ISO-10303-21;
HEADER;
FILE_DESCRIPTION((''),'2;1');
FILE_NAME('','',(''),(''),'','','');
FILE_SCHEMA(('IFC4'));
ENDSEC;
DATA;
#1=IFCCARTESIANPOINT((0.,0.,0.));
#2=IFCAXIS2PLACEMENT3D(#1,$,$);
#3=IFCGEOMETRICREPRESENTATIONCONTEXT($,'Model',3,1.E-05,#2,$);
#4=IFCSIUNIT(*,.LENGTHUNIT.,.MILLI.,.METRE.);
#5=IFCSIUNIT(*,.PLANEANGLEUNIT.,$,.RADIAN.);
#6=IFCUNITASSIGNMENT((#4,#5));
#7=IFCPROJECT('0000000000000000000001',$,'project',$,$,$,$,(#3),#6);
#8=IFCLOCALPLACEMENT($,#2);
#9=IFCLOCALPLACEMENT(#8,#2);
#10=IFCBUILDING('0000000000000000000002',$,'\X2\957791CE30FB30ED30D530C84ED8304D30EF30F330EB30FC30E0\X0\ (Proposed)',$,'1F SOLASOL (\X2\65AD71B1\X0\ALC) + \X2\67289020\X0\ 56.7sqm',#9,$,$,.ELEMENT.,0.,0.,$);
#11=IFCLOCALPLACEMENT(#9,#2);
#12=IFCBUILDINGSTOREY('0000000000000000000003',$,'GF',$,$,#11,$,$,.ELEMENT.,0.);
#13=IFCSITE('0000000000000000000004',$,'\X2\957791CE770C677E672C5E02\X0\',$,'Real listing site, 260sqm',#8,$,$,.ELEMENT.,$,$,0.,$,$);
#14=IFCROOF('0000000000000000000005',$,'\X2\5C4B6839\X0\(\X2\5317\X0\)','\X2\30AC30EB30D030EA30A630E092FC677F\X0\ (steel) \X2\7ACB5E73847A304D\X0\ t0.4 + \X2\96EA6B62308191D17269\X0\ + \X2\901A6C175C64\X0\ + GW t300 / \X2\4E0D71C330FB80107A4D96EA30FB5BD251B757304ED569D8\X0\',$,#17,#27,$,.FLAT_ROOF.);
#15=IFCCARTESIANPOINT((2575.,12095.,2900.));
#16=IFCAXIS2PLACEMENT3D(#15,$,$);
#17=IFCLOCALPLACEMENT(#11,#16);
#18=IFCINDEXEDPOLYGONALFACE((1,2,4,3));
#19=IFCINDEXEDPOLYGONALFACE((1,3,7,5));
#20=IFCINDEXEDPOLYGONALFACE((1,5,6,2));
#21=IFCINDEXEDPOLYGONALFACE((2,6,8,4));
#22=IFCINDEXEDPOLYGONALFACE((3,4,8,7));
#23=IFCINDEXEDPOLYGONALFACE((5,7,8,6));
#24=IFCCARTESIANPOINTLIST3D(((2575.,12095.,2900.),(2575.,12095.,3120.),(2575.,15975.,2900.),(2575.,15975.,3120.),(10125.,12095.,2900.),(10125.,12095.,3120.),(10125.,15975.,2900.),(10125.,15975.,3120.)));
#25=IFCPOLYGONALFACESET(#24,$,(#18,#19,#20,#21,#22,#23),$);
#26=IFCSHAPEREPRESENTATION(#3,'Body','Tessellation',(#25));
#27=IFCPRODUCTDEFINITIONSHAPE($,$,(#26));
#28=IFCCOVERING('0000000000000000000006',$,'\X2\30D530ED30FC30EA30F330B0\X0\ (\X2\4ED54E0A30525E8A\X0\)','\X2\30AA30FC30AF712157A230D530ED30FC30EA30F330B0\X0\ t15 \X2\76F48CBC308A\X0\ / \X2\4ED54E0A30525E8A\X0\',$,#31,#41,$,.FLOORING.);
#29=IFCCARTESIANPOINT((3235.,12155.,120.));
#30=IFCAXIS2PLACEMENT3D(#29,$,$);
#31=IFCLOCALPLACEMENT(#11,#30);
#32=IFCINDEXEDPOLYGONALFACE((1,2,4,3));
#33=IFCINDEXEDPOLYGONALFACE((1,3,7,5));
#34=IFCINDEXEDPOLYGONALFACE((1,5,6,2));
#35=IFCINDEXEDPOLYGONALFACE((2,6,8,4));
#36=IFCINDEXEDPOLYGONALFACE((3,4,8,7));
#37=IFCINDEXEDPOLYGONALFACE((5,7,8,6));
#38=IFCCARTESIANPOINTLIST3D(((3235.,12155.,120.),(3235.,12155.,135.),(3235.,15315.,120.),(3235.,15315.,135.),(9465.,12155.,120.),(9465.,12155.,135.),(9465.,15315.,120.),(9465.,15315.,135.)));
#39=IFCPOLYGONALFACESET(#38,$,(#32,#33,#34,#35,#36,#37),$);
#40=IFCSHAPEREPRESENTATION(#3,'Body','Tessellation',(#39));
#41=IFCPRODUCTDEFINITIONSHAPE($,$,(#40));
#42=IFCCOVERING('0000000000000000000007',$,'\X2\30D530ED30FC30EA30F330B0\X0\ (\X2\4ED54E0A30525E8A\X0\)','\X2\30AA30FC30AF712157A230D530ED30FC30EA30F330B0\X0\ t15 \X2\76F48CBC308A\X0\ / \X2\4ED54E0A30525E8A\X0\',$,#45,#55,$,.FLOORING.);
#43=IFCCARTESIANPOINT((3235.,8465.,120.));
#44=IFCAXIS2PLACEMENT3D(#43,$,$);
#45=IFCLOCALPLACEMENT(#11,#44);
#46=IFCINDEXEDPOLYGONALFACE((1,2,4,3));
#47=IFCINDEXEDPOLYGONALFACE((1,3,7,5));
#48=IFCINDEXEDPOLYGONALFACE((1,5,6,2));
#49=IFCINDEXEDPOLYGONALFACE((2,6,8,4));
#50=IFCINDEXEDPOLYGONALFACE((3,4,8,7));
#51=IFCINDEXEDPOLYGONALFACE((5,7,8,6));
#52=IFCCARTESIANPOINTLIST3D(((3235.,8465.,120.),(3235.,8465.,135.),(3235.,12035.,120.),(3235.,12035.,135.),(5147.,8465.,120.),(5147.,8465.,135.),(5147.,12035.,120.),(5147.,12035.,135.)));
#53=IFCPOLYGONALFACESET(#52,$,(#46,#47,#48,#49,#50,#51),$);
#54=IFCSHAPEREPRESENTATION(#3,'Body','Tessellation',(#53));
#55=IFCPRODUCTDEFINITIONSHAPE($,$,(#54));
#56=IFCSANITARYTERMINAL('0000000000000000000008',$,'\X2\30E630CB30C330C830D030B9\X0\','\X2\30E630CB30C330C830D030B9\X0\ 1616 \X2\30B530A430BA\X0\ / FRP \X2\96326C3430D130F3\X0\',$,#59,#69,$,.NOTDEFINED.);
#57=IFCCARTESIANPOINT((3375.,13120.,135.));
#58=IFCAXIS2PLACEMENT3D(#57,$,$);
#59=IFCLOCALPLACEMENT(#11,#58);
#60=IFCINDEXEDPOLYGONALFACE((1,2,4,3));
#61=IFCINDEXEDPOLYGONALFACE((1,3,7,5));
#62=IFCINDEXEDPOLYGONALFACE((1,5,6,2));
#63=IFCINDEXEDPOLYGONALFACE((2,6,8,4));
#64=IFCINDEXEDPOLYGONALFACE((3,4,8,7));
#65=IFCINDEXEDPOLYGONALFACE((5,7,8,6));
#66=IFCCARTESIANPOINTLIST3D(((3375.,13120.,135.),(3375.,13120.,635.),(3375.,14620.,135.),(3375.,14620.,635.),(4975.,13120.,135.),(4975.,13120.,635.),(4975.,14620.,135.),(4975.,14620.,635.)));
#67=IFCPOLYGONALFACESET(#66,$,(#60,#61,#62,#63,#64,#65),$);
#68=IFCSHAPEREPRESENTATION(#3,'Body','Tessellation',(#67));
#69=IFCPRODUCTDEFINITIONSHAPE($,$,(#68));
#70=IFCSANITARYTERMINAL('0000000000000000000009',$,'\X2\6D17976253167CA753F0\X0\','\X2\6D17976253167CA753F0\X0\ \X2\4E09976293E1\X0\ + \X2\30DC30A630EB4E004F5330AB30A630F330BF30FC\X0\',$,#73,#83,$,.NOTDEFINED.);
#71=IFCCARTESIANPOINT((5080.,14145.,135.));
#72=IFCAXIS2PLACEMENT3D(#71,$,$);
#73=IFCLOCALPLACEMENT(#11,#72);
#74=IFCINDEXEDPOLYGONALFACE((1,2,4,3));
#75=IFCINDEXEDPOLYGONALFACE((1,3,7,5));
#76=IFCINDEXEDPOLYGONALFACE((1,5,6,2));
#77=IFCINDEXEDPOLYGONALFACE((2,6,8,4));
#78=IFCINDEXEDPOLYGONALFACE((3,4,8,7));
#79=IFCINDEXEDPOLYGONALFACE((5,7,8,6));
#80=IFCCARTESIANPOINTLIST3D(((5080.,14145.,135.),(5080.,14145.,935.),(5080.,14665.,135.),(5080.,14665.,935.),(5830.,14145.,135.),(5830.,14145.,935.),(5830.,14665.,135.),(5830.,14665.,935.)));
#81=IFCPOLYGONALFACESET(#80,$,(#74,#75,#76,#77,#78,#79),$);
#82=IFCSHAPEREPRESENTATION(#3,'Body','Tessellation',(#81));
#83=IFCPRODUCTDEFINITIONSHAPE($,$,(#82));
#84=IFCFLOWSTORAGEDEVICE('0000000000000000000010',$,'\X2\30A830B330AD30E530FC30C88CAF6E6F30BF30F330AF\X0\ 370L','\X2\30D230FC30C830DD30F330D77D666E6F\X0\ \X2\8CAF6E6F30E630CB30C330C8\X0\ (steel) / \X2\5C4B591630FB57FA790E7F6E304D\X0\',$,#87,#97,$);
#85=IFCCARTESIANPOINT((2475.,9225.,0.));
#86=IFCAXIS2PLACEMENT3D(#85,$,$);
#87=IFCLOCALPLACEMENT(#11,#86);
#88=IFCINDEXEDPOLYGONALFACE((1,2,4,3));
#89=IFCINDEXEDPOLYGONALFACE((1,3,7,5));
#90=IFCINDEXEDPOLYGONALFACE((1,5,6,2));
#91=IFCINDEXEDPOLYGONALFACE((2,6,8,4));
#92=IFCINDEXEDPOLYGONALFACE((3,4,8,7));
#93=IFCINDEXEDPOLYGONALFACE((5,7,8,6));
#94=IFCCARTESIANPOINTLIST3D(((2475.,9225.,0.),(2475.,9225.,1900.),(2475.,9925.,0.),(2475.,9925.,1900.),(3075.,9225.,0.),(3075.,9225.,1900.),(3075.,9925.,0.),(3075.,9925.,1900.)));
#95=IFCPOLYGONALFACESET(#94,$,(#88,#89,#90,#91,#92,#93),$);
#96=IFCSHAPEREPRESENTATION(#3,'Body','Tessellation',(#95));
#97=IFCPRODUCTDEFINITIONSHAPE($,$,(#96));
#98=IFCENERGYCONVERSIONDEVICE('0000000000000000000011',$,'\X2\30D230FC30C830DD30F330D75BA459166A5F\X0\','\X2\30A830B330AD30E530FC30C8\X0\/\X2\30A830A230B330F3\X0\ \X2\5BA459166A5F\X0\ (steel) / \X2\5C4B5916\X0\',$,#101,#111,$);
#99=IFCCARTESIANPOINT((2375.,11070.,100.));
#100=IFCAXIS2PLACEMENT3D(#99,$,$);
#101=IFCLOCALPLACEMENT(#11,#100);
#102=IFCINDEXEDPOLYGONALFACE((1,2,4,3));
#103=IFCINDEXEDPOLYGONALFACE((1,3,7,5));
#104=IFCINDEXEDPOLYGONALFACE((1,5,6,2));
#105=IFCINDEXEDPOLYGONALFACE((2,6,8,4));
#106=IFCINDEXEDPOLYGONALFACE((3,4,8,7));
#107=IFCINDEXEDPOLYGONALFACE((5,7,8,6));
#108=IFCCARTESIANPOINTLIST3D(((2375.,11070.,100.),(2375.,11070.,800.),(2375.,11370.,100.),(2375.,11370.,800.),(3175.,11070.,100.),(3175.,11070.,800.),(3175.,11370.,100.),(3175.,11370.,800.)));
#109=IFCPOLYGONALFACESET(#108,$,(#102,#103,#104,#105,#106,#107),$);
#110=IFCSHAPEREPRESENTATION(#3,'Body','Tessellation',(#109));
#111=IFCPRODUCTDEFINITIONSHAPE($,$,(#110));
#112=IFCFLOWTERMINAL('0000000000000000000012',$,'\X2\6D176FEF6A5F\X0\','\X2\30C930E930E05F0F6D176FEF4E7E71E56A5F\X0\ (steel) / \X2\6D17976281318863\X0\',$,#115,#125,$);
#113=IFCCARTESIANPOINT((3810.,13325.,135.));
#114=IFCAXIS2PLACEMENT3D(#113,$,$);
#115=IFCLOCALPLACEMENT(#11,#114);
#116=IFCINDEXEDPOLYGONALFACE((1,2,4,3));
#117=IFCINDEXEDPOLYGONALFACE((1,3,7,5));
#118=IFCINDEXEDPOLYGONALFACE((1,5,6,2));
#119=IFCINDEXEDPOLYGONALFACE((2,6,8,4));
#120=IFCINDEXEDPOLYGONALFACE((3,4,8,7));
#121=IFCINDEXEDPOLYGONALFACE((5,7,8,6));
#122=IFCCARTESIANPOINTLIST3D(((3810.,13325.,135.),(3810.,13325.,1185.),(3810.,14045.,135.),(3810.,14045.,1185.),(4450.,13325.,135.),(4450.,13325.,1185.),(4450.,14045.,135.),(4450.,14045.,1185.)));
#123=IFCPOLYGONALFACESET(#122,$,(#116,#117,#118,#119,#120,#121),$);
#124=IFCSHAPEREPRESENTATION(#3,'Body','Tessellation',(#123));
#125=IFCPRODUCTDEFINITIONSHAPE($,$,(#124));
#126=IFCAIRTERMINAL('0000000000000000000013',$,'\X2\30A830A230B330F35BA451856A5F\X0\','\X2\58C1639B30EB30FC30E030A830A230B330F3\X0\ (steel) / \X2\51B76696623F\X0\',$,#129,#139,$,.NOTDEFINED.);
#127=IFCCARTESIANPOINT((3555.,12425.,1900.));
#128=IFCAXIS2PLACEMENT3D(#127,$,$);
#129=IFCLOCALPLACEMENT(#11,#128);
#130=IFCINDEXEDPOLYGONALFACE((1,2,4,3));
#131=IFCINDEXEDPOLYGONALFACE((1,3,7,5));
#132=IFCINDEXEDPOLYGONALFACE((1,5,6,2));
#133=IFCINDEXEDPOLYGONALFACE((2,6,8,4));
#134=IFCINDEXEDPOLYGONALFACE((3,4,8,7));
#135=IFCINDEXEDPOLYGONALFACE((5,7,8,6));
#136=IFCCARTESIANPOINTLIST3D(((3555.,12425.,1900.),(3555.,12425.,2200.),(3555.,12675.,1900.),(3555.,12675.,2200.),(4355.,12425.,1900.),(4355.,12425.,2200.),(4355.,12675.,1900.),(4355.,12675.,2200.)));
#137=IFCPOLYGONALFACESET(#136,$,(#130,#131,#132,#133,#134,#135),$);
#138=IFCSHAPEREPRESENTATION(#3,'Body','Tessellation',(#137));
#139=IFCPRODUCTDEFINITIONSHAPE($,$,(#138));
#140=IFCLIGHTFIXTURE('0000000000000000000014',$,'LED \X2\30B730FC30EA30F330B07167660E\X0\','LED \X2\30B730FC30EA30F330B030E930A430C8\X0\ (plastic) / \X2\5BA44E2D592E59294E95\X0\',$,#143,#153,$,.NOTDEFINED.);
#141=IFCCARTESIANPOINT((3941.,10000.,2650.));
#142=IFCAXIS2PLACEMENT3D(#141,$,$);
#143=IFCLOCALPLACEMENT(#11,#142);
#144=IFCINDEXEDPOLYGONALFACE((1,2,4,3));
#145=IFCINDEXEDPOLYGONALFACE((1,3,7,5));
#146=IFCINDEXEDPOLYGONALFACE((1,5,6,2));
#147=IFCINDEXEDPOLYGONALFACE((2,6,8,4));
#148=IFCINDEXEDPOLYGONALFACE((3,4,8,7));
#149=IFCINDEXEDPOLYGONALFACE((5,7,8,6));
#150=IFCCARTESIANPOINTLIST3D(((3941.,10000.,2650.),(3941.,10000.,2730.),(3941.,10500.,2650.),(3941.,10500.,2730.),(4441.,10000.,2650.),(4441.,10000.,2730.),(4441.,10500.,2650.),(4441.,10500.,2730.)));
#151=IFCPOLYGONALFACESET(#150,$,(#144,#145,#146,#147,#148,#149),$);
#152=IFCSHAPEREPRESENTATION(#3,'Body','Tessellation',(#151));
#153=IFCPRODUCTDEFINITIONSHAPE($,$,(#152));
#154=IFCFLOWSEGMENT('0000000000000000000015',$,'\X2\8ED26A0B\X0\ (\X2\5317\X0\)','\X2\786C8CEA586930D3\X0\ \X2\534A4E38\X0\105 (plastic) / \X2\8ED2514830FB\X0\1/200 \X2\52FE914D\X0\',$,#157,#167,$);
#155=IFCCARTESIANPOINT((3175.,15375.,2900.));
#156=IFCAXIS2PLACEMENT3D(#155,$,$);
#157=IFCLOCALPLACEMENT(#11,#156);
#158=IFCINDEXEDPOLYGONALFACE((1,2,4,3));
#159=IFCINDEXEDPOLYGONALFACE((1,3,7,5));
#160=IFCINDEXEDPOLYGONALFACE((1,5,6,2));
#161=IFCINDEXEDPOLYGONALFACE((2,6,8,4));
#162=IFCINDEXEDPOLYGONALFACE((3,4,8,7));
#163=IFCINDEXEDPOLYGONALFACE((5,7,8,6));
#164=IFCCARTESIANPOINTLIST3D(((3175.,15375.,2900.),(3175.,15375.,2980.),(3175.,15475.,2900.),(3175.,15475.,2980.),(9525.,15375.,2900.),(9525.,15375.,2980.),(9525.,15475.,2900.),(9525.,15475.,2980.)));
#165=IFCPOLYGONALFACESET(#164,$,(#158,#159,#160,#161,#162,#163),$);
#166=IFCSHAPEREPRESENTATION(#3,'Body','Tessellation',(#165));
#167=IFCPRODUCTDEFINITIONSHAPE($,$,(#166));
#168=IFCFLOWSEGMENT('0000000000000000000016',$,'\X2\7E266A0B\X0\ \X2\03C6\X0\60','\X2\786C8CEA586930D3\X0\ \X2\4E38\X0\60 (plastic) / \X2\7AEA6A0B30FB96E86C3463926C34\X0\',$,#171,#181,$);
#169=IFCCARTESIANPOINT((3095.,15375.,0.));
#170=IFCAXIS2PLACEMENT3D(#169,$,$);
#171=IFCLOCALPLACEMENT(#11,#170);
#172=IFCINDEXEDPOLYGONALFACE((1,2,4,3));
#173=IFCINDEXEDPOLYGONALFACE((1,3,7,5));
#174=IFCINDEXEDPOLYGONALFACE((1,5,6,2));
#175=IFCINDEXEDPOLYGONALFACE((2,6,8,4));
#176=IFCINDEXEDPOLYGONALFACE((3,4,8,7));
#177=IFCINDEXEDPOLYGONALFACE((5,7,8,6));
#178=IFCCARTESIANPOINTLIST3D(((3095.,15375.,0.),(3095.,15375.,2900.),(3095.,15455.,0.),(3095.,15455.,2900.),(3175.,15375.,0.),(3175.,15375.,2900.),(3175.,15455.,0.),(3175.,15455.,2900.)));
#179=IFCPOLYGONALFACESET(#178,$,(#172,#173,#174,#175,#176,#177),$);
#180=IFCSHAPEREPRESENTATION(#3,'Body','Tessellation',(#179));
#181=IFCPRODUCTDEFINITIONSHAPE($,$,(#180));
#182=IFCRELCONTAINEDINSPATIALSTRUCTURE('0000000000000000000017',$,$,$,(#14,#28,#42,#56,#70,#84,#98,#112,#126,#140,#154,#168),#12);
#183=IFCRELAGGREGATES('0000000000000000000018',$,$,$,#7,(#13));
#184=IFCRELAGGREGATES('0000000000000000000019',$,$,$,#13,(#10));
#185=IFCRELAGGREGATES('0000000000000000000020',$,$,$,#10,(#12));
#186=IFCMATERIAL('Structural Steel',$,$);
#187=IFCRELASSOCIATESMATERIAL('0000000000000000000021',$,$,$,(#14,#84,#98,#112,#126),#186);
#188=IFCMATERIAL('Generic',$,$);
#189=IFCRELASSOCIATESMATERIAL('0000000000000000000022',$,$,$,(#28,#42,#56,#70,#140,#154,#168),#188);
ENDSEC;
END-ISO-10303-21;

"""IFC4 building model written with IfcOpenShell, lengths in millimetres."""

from ifc_helpers import new_model, si_unit, frame, frame_2d, origin, place, context, project, spatial, rectangle, extrude, material, element, save


model = new_model("IFC4")

# Units and contexts
model_context = context("Model", 3, precision=1e-05, world=origin())
ifc_project = project(units=[si_unit("LENGTHUNIT", "METRE", prefix="MILLI"), si_unit("PLANEANGLEUNIT", "RADIAN")], contexts=[model_context])

# Site, building, storey
site_placement = place(None, origin())
site = spatial("IfcSite", under=ifc_project, at=site_placement, Name="長野県松本市", ObjectType="Real listing site, 260sqm", CompositionType="ELEMENT", RefElevation=0.0)
building_placement = place(site_placement, origin())
building = spatial("IfcBuilding", under=site, at=building_placement, Name="長野・ロフト付きワンルーム (Proposed)", ObjectType="1F SOLASOL (断熱ALC) + 木造 56.7sqm", CompositionType="ELEMENT", ElevationOfRefHeight=0.0, ElevationOfTerrain=0.0)
storey_placement = place(building_placement, origin())
storey = spatial("IfcBuildingStorey", under=building, at=storey_placement, Name="GF", CompositionType="ELEMENT", Elevation=0.0)

# Roof
ifc_material_1 = material(Name="Structural Steel")
roof_placement = place(storey_placement, frame((2575.0, 12095.0, 2900.0)))
element("IfcRoof", 1, at=roof_placement, inside=storey, material=ifc_material_1, Name="屋根(北)", Description="ガルバリウム鋼板 (steel) 立平葺き t0.4 + 雪止め金物 + 通気層 + GW t300 / 不燃・耐積雪・寒冷地仕様", PredefinedType="FLAT_ROOF", context=model_context, shape_type="SweptSolid", body=[
    extrude(rectangle(XDim=7550.0, YDim=3880.0, at=frame_2d((3775.0, 1940.0))), frame((2575.0, 12095.0, 2900.0)), (0.0, 0.0, 1.0), 220.0),
])

# Coverings
ifc_material_2 = material(Name="Generic")
covering_1_placement = place(storey_placement, frame((3235.0, 12155.0, 120.0)))
element("IfcCovering", 2, at=covering_1_placement, inside=storey, material=ifc_material_2, Name="フローリング (仕上げ床)", Description="オーク無垢フローリング t15 直貼り / 仕上げ床", PredefinedType="FLOORING", context=model_context, shape_type="SweptSolid", body=[
    extrude(rectangle(XDim=6230.0, YDim=3160.0, at=frame_2d((3115.0, 1580.0))), frame((3235.0, 12155.0, 120.0)), (0.0, 0.0, 1.0), 15.0),
])
covering_2_placement = place(storey_placement, frame((3235.0, 8465.0, 120.0)))
element("IfcCovering", 3, at=covering_2_placement, inside=storey, material=ifc_material_2, Name="フローリング (仕上げ床)", Description="オーク無垢フローリング t15 直貼り / 仕上げ床", PredefinedType="FLOORING", context=model_context, shape_type="SweptSolid", body=[
    extrude(rectangle(XDim=1912.0, YDim=3570.0, at=frame_2d((956.0, 1785.0))), frame((3235.0, 8465.0, 120.0)), (0.0, 0.0, 1.0), 15.0),
])

# Sanitary terminals
sanitary_terminal_1_placement = place(storey_placement, frame((3375.0, 13120.0, 135.0)))
element("IfcSanitaryTerminal", 4, at=sanitary_terminal_1_placement, inside=storey, material=ifc_material_2, Name="ユニットバス", Description="ユニットバス 1616 サイズ / FRP 防水パン", PredefinedType="NOTDEFINED", context=model_context, shape_type="SweptSolid", body=[
    extrude(rectangle(XDim=1600.0, YDim=1500.0, at=frame_2d((800.0, 750.0))), frame((3375.0, 13120.0, 135.0)), (0.0, 0.0, 1.0), 500.0),
])
sanitary_terminal_2_placement = place(storey_placement, frame((5080.0, 14145.0, 135.0)))
element("IfcSanitaryTerminal", 5, at=sanitary_terminal_2_placement, inside=storey, material=ifc_material_2, Name="洗面化粧台", Description="洗面化粧台 三面鏡 + ボウル一体カウンター", PredefinedType="NOTDEFINED", context=model_context, shape_type="SweptSolid", body=[
    extrude(rectangle(XDim=750.0, YDim=520.0, at=frame_2d((375.0, 260.0))), frame((5080.0, 14145.0, 135.0)), (0.0, 0.0, 1.0), 800.0),
])

# Flow storage device
flow_storage_device_placement = place(storey_placement, frame((2475.0, 9225.0, 0.0)))
element("IfcFlowStorageDevice", 6, at=flow_storage_device_placement, inside=storey, material=ifc_material_1, Name="エコキュート貯湯タンク 370L", Description="ヒートポンプ給湯 貯湯ユニット (steel) / 屋外・基礎置き", context=model_context, shape_type="SweptSolid", body=[
    extrude(rectangle(XDim=600.0, YDim=700.0, at=frame_2d((300.0, 350.0))), frame((2475.0, 9225.0, 0.0)), (0.0, 0.0, 1.0), 1900.0),
])

# Energy conversion device
energy_conversion_device_placement = place(storey_placement, frame((2375.0, 11070.0, 100.0)))
element("IfcEnergyConversionDevice", 7, at=energy_conversion_device_placement, inside=storey, material=ifc_material_1, Name="ヒートポンプ室外機", Description="エコキュート/エアコン 室外機 (steel) / 屋外", context=model_context, shape_type="SweptSolid", body=[
    extrude(rectangle(XDim=800.0, YDim=300.0, at=frame_2d((400.0, 150.0))), frame((2375.0, 11070.0, 100.0)), (0.0, 0.0, 1.0), 700.0),
])

# Flow terminal
flow_terminal_placement = place(storey_placement, frame((3810.0, 13325.0, 135.0)))
element("IfcFlowTerminal", 8, at=flow_terminal_placement, inside=storey, material=ifc_material_1, Name="洗濯機", Description="ドラム式洗濯乾燥機 (steel) / 洗面脱衣", context=model_context, shape_type="SweptSolid", body=[
    extrude(rectangle(XDim=640.0, YDim=720.0, at=frame_2d((320.0, 360.0))), frame((3810.0, 13325.0, 135.0)), (0.0, 0.0, 1.0), 1050.0),
])

# Air terminal
air_terminal_placement = place(storey_placement, frame((3555.0, 12425.0, 1900.0)))
element("IfcAirTerminal", 9, at=air_terminal_placement, inside=storey, material=ifc_material_1, Name="エアコン室内機", Description="壁掛ルームエアコン (steel) / 冷暖房", PredefinedType="NOTDEFINED", context=model_context, shape_type="SweptSolid", body=[
    extrude(rectangle(XDim=800.0, YDim=250.0, at=frame_2d((400.0, 125.0))), frame((3555.0, 12425.0, 1900.0)), (0.0, 0.0, 1.0), 300.0),
])

# Light fixture
light_fixture_placement = place(storey_placement, frame((3941.0, 10000.0, 2650.0)))
element("IfcLightFixture", 10, at=light_fixture_placement, inside=storey, material=ifc_material_2, Name="LED シーリング照明", Description="LED シーリングライト (plastic) / 室中央天井", PredefinedType="NOTDEFINED", context=model_context, shape_type="SweptSolid", body=[
    extrude(rectangle(XDim=500.0, YDim=500.0, at=frame_2d((250.0, 250.0))), frame((3941.0, 10000.0, 2650.0)), (0.0, 0.0, 1.0), 80.0),
])

# Flow segments
flow_segment_1_placement = place(storey_placement, frame((3175.0, 15375.0, 2900.0)))
element("IfcFlowSegment", 11, at=flow_segment_1_placement, inside=storey, material=ifc_material_2, Name="軒樋 (北)", Description="硬質塩ビ 半丸105 (plastic) / 軒先・1/200 勾配", context=model_context, shape_type="SweptSolid", body=[
    extrude(rectangle(XDim=6350.0, YDim=100.0, at=frame_2d((3175.0, 50.0))), frame((3175.0, 15375.0, 2900.0)), (0.0, 0.0, 1.0), 80.0),
])
flow_segment_2_placement = place(storey_placement, frame((3095.0, 15375.0, 0.0)))
element("IfcFlowSegment", 12, at=flow_segment_2_placement, inside=storey, material=ifc_material_2, Name="縦樋 φ60", Description="硬質塩ビ 丸60 (plastic) / 竪樋・雨水排水", context=model_context, shape_type="SweptSolid", body=[
    extrude(rectangle(XDim=80.0, YDim=80.0, at=frame_2d((40.0, 40.0))), frame((3095.0, 15375.0, 0.0)), (0.0, 0.0, 1.0), 2900.0),
])

save(model, "model.ifc")
